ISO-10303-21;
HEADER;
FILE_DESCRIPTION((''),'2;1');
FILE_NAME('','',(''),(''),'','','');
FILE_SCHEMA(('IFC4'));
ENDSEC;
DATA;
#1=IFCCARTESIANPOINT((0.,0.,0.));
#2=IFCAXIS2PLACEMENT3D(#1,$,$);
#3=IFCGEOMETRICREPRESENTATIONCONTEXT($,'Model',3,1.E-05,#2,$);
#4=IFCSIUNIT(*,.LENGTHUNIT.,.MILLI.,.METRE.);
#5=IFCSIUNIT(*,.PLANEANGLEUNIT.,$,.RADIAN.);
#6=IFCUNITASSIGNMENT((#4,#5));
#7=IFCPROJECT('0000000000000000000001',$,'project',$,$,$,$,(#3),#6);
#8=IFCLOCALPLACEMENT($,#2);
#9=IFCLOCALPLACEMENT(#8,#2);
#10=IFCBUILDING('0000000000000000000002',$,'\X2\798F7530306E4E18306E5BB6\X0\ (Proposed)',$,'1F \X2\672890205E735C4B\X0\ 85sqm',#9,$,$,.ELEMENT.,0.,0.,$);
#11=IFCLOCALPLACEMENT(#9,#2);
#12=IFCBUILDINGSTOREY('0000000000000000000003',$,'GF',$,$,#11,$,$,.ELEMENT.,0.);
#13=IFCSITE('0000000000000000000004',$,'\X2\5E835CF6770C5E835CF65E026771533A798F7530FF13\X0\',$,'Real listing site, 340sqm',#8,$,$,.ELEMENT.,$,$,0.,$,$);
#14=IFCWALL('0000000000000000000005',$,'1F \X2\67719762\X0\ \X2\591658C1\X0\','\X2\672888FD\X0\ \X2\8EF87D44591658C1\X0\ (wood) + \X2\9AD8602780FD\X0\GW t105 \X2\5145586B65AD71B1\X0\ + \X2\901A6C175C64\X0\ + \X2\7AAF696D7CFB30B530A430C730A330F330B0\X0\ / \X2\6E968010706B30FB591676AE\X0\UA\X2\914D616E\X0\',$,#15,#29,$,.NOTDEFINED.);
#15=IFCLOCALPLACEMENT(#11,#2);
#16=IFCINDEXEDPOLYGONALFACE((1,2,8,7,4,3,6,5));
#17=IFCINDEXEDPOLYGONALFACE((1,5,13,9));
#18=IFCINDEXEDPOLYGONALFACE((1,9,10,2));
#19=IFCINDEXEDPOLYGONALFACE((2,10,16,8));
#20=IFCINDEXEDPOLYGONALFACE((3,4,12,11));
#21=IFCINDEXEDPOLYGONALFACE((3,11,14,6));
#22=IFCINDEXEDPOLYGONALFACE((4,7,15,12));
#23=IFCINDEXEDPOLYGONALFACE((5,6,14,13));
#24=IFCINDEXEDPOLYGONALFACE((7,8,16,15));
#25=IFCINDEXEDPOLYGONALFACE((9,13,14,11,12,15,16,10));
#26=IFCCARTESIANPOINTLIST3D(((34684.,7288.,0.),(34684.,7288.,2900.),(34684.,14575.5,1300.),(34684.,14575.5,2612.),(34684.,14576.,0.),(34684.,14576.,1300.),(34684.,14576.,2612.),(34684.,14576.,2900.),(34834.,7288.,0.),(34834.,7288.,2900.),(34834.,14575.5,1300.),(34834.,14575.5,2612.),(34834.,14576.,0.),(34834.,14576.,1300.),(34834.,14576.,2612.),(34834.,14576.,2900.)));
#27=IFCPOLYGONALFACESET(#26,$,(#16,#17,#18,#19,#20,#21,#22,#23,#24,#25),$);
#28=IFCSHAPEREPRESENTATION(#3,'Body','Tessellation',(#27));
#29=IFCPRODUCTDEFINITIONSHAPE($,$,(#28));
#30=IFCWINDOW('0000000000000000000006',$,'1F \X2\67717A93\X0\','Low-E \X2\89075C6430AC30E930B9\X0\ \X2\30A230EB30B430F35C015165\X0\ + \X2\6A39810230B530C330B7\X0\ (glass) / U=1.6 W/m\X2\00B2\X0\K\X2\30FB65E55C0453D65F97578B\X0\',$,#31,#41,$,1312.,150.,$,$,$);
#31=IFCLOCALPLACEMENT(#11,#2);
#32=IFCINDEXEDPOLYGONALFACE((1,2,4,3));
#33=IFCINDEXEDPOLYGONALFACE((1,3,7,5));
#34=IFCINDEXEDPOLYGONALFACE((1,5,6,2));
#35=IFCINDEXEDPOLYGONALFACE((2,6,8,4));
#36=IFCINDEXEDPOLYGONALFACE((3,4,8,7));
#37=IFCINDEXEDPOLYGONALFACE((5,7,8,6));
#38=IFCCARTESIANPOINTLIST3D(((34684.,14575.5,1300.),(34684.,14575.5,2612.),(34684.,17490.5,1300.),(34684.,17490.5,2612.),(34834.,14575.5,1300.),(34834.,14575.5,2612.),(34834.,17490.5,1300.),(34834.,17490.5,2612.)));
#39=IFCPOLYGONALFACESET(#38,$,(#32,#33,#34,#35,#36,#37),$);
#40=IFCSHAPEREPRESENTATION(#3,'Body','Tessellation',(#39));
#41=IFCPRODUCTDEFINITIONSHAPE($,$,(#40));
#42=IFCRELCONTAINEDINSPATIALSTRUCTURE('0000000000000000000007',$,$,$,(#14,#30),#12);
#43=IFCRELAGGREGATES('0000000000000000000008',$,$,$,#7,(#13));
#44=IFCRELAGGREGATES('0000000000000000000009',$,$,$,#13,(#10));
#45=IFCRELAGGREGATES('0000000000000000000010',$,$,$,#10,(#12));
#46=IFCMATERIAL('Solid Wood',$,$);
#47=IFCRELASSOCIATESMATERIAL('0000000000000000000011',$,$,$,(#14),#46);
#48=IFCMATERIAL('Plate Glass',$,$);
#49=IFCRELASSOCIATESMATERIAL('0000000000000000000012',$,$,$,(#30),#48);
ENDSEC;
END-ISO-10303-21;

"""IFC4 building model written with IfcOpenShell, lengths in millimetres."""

from ifc_helpers import new_model, si_unit, frame, frame_2d, origin, place, context, project, spatial, rectangle, extrude, material, element, fill, save


model = new_model("IFC4")

# Units and contexts
model_context = context("Model", 3, precision=1e-05, world=origin())
ifc_project = project(units=[si_unit("LENGTHUNIT", "METRE", prefix="MILLI"), si_unit("PLANEANGLEUNIT", "RADIAN")], contexts=[model_context])

# Site, building, storey
site_placement = place(None, origin())
site = spatial("IfcSite", under=ifc_project, at=site_placement, Name="広島県広島市東区福田３", ObjectType="Real listing site, 340sqm", CompositionType="ELEMENT", RefElevation=0.0)
building_placement = place(site_placement, origin())
building = spatial("IfcBuilding", under=site, at=building_placement, Name="福田の丘の家 (Proposed)", ObjectType="1F 木造平屋 85sqm", CompositionType="ELEMENT", ElevationOfRefHeight=0.0, ElevationOfTerrain=0.0)
storey_placement = place(building_placement, origin())
storey = spatial("IfcBuildingStorey", under=building, at=storey_placement, Name="GF", CompositionType="ELEMENT", Elevation=0.0)

# Shared definitions
ifc_material_1 = material(Name="Solid Wood")

# Wall, opening, window
wall_1_placement = place(storey_placement, frame((17342.0, 3644.0, 0.0)))
wall_1 = element("IfcWall", 1, at=wall_1_placement, inside=storey, material=ifc_material_1, Name="1F 東面 外壁", Description="木製 軸組外壁 (wood) + 高性能GW t105 充填断熱 + 通気層 + 窯業系サイディング / 準耐火・外皮UA配慮", PredefinedType="NOTDEFINED", context=model_context, shape_type="SweptSolid", body=[
    extrude(rectangle(XDim=150.0, YDim=7288.0, at=frame_2d((75.0, 3644.0))), frame((17342.0, 3644.0, 0.0)), (0.0, 0.0, 1.0), 2900.0),
])
opening_placement = place(storey_placement, frame((17342.0, 7288.0, 650.0)))
opening = element("IfcOpeningElement", 2, at=opening_placement, cuts=wall_1, PredefinedType="NOTDEFINED", context=model_context, shape_type="SweptSolid", body=[
    extrude(rectangle(XDim=150.0, YDim=2915.0, at=frame_2d((75.0, 1457.0))), frame((17342.0, 7288.0, 650.0)), (0.0, 0.0, 1.0), 1312.0),
])
ifc_material_2 = material(Name="Plate Glass")
window_placement = place(storey_placement, frame((17342.0, 7288.0, 650.0)))
window = element("IfcWindow", 3, at=window_placement, inside=storey, material=ifc_material_2, Name="1F 東窓", Description="Low-E 複層ガラス アルゴン封入 + 樹脂サッシ (glass) / U=1.6 W/m²K・日射取得型", OverallHeight=1312.0, OverallWidth=150.0, context=model_context, shape_type="SweptSolid", body=[
    extrude(rectangle(XDim=150.0, YDim=2915.0, at=frame_2d((75.0, 1457.0))), frame((17342.0, 7288.0, 650.0)), (0.0, 0.0, 1.0), 1312.0),
])
fill(opening, window)

save(model, "model.ifc")
